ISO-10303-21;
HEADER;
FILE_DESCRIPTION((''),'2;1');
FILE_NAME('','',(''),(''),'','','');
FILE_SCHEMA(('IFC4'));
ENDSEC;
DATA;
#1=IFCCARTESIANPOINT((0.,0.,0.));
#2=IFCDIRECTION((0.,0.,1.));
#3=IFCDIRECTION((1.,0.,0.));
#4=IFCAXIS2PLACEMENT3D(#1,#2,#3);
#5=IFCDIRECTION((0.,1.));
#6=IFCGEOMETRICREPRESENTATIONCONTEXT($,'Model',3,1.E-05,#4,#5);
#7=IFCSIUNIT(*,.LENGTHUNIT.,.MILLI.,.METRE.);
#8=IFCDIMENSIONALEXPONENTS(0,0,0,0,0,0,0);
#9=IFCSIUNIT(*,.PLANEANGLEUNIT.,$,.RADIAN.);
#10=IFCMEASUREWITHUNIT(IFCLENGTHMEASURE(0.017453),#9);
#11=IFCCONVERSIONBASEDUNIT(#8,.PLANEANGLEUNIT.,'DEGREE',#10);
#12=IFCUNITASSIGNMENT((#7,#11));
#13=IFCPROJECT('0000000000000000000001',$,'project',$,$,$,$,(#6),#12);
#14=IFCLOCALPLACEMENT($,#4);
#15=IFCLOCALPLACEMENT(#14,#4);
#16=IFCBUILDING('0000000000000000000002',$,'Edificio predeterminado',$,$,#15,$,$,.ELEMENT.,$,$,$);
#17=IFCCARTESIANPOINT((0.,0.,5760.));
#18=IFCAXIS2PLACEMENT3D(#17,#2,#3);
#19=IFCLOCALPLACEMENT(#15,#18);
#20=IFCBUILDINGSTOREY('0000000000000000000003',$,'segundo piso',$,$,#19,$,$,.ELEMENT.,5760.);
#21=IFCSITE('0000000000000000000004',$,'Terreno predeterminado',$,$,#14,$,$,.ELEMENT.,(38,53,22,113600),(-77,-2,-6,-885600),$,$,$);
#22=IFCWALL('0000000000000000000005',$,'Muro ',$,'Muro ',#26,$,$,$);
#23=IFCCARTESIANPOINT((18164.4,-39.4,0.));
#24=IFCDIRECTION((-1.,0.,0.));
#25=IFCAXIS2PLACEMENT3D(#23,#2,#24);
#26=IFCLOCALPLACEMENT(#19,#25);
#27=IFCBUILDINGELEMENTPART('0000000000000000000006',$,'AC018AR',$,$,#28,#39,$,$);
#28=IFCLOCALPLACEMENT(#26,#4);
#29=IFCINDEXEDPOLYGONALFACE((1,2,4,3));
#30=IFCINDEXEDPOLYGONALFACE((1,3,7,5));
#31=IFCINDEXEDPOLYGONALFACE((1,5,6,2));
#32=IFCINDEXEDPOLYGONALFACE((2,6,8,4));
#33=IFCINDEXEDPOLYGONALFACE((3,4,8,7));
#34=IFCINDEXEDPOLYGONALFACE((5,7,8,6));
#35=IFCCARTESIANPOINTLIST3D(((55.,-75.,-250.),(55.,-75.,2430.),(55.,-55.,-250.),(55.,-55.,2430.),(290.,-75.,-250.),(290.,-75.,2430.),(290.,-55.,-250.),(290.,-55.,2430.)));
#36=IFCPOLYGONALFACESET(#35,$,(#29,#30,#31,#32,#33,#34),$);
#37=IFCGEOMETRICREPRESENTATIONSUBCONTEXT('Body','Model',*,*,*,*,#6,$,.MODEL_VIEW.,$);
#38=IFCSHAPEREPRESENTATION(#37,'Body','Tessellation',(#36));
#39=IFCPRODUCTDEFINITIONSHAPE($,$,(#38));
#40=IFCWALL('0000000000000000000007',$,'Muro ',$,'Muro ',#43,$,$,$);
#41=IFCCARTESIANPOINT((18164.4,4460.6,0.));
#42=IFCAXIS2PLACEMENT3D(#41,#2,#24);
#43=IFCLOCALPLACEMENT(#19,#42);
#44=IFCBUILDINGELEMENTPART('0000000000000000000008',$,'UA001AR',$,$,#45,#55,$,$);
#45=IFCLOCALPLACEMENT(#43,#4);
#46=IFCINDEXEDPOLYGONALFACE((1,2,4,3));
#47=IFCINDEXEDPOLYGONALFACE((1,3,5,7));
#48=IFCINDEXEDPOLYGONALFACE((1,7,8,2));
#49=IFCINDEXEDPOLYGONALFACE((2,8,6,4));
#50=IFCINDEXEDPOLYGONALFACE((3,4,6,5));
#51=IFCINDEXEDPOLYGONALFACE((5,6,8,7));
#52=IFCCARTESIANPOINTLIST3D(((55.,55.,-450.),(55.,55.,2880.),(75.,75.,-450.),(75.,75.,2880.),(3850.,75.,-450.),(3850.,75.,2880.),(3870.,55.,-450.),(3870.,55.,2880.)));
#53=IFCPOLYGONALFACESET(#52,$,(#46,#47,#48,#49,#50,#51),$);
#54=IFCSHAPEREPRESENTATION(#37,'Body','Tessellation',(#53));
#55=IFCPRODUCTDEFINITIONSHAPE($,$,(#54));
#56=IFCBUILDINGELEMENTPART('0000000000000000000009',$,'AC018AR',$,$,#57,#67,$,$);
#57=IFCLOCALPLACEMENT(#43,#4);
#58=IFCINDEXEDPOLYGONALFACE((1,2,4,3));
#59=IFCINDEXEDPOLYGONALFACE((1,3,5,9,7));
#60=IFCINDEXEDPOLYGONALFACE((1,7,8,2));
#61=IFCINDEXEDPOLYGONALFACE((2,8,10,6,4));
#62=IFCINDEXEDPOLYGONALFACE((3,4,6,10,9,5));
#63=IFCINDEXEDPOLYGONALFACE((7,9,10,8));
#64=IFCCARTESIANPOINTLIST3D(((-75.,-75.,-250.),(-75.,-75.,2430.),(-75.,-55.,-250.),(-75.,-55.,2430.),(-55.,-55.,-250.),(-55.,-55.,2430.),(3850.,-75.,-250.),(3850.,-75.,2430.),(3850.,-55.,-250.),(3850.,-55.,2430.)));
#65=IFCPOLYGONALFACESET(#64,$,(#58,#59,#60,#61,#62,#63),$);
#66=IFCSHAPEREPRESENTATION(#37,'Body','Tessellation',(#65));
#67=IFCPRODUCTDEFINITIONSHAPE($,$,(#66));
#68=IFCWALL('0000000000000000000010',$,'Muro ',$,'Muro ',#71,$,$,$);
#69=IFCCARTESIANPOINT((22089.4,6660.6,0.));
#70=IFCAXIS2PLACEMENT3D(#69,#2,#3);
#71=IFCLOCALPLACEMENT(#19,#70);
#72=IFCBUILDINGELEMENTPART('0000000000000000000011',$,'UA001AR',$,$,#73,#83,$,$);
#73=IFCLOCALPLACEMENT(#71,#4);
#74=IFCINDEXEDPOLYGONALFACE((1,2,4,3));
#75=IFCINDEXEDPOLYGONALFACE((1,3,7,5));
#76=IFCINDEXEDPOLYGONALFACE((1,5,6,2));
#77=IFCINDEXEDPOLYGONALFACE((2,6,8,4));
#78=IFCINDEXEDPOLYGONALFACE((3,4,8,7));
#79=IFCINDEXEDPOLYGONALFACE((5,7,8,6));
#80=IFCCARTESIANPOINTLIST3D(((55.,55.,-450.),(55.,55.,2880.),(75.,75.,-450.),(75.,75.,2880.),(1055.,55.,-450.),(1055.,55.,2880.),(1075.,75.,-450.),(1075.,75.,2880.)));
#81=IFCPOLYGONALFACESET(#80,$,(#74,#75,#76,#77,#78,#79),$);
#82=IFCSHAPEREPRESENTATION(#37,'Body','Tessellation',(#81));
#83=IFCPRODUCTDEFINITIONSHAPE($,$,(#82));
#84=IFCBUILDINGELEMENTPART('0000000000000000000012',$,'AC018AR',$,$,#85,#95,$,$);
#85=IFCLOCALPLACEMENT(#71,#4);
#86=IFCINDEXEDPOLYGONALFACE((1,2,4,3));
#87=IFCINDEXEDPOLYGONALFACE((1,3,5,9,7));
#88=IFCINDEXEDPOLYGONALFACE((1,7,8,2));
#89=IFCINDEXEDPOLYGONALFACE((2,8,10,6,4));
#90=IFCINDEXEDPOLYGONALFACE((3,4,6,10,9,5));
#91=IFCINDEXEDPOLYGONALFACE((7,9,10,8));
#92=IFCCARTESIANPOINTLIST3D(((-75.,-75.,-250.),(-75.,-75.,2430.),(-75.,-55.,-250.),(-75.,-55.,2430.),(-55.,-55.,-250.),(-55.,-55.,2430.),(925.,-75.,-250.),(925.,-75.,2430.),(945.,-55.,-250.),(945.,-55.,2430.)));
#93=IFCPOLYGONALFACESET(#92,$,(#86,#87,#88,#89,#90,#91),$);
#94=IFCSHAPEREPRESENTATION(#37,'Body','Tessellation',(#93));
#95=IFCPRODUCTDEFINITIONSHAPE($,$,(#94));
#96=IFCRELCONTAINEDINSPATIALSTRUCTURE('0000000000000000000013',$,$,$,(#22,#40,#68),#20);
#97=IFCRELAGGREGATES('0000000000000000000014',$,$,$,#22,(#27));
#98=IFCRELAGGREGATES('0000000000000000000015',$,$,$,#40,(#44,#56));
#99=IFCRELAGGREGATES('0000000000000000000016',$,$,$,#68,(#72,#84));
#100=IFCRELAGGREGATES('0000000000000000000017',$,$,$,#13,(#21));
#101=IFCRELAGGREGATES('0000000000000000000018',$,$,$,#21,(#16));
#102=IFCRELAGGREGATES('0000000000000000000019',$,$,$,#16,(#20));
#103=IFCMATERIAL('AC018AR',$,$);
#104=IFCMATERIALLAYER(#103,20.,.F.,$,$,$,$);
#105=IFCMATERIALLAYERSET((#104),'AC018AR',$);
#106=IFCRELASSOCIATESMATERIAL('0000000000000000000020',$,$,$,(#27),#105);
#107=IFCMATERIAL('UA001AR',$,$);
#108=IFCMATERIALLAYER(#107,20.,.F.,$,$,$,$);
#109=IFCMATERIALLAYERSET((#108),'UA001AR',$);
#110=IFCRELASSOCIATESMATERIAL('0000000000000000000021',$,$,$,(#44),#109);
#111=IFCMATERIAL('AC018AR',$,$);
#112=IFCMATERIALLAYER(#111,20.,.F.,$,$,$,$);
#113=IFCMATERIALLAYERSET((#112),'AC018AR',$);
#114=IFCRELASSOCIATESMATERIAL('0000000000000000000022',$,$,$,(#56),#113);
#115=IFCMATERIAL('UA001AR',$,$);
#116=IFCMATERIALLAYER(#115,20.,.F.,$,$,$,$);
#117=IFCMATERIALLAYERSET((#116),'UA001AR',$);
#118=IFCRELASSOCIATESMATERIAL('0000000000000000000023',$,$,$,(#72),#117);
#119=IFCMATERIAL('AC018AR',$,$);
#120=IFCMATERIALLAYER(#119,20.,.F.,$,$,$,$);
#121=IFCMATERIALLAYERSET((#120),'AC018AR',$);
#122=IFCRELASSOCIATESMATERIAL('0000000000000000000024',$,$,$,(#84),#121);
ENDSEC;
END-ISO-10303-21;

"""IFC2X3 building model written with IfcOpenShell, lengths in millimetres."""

from ifc_helpers import new_model, entity, si_unit, converted_unit, direction, frame, origin_with_axes, place, context, subcontext, project, spatial, polyline, outline, extrude, material, layer, layer_set, layer_usage, element, aggregate, save


model = new_model("IFC2X3")

# Units and contexts
model_context = context("Model", 3, precision=1e-05, world=origin_with_axes(), true_north=direction((0.0, 1.0)))
body_context = subcontext(model_context, "Body", "Model", "MODEL_VIEW")
ifc_project = project(units=[si_unit("LENGTHUNIT", "METRE", prefix="MILLI"), converted_unit("PLANEANGLEUNIT", "DEGREE", entity("IfcLengthMeasure", 0.017453), si_unit("PLANEANGLEUNIT", "RADIAN"), dimensions=[0, 0, 0, 0, 0, 0, 0])], contexts=[model_context])

# Site, building, storey
site_placement = place(None, origin_with_axes())
site = spatial("IfcSite", under=ifc_project, at=site_placement, Name="Terreno predeterminado", CompositionType="ELEMENT", RefLatitude=(38, 53, 22, 113600), RefLongitude=(-77, -2, -6, -885600))
building_placement = place(site_placement, origin_with_axes())
building = spatial("IfcBuilding", under=site, at=building_placement, Name="Edificio predeterminado", CompositionType="ELEMENT")
storey_placement = place(building_placement, frame((0.0, 0.0, 5760.0), z_axis=(0.0, 0.0, 1.0), x_axis=(1.0, 0.0, 0.0)))
storey = spatial("IfcBuildingStorey", under=building, at=storey_placement, Name="segundo piso", CompositionType="ELEMENT", Elevation=5760.0)

# Wall, building element part
wall_1_placement = place(storey_placement, frame((18164.4, -39.4, 0.0), z_axis=(0.0, 0.0, 1.0), x_axis=(-1.0, 0.0, 0.0)))
wall_1 = element("IfcWall", 1, at=wall_1_placement, inside=storey, Name="Muro ", ObjectType="Muro ")
ifc_material_1 = material(Name="AC018AR")
ifc_layer_1 = layer(ifc_material_1, 20.0, ventilated=False)
ifc_layer_set_1 = layer_set([ifc_layer_1], Name="AC018AR")
ifc_layer_usage_1 = layer_usage(ifc_layer_set_1, "AXIS2", "NEGATIVE", 55.0)
building_element_part_1_placement = place(wall_1_placement, origin_with_axes())
building_element_part_1 = element("IfcBuildingElementPart", 2, at=building_element_part_1_placement, material=ifc_layer_usage_1, Name="AC018AR", context=body_context, shape_type="SweptSolid", body=[
    extrude(outline(polyline([(290.0, -55.0), (290.0, -75.0), (55.0, -75.0), (55.0, -55.0), (290.0, -55.0)])), frame((0.0, 0.0, -250.0), z_axis=(0.0, 0.0, 1.0), x_axis=(1.0, 0.0, 0.0)), (0.0, 0.0, 1.0), 2680.0),
])
aggregate(wall_1, [building_element_part_1])

# Walls, building element parts
wall_2_placement = place(storey_placement, frame((18164.4, 4460.6, 0.0), z_axis=(0.0, 0.0, 1.0), x_axis=(-1.0, 0.0, 0.0)))
wall_2 = element("IfcWall", 3, at=wall_2_placement, inside=storey, Name="Muro ", ObjectType="Muro ")
ifc_material_2 = material(Name="UA001AR")
ifc_layer_2 = layer(ifc_material_2, 20.0, ventilated=False)
ifc_layer_set_2 = layer_set([ifc_layer_2], Name="UA001AR")
ifc_layer_usage_2 = layer_usage(ifc_layer_set_2, "AXIS2", "NEGATIVE", -75.0)
building_element_part_2_placement = place(wall_2_placement, origin_with_axes())
building_element_part_2 = element("IfcBuildingElementPart", 4, at=building_element_part_2_placement, material=ifc_layer_usage_2, Name="UA001AR", context=body_context, shape_type="SweptSolid", body=[
    extrude(outline(polyline([(3850.0, 75.0), (3870.0, 55.0), (55.0, 55.0), (75.0, 75.0), (3850.0, 75.0)])), frame((0.0, 0.0, -450.0), z_axis=(0.0, 0.0, 1.0), x_axis=(1.0, 0.0, 0.0)), (0.0, 0.0, 1.0), 3330.0),
])
ifc_material_3 = material(Name="AC018AR")
ifc_layer_3 = layer(ifc_material_3, 20.0, ventilated=False)
ifc_layer_set_3 = layer_set([ifc_layer_3], Name="AC018AR")
ifc_layer_usage_3 = layer_usage(ifc_layer_set_3, "AXIS2", "NEGATIVE", 55.0)
building_element_part_3_placement = place(wall_2_placement, origin_with_axes())
building_element_part_3 = element("IfcBuildingElementPart", 5, at=building_element_part_3_placement, material=ifc_layer_usage_3, Name="AC018AR", context=body_context, shape_type="SweptSolid", body=[
    extrude(outline(polyline([(3850.0, -55.0), (3850.0, -75.0), (-75.0, -75.0), (-75.0, -55.0), (-55.0, -55.0), (3850.0, -55.0)])), frame((0.0, 0.0, -250.0), z_axis=(0.0, 0.0, 1.0), x_axis=(1.0, 0.0, 0.0)), (0.0, 0.0, 1.0), 2680.0),
])
aggregate(wall_2, [building_element_part_2, building_element_part_3])
wall_3_placement = place(storey_placement, frame((22089.4, 6660.6, 0.0), z_axis=(0.0, 0.0, 1.0), x_axis=(1.0, 0.0, 0.0)))
wall_3 = element("IfcWall", 6, at=wall_3_placement, inside=storey, Name="Muro ", ObjectType="Muro ")
ifc_material_4 = material(Name="UA001AR")
ifc_layer_4 = layer(ifc_material_4, 20.0, ventilated=False)
ifc_layer_set_4 = layer_set([ifc_layer_4], Name="UA001AR")
ifc_layer_usage_4 = layer_usage(ifc_layer_set_4, "AXIS2", "NEGATIVE", -75.0)
building_element_part_4_placement = place(wall_3_placement, origin_with_axes())
building_element_part_4 = element("IfcBuildingElementPart", 7, at=building_element_part_4_placement, material=ifc_layer_usage_4, Name="UA001AR", context=body_context, shape_type="SweptSolid", body=[
    extrude(outline(polyline([(1075.0, 75.0), (1055.0, 55.0), (55.0, 55.0), (75.0, 75.0), (1075.0, 75.0)])), frame((0.0, 0.0, -450.0), z_axis=(0.0, 0.0, 1.0), x_axis=(1.0, 0.0, 0.0)), (0.0, 0.0, 1.0), 3330.0),
])
ifc_material_5 = material(Name="AC018AR")
ifc_layer_5 = layer(ifc_material_5, 20.0, ventilated=False)
ifc_layer_set_5 = layer_set([ifc_layer_5], Name="AC018AR")
ifc_layer_usage_5 = layer_usage(ifc_layer_set_5, "AXIS2", "NEGATIVE", 55.0)
building_element_part_5_placement = place(wall_3_placement, origin_with_axes())
building_element_part_5 = element("IfcBuildingElementPart", 8, at=building_element_part_5_placement, material=ifc_layer_usage_5, Name="AC018AR", context=body_context, shape_type="SweptSolid", body=[
    extrude(outline(polyline([(945.0, -55.0), (925.0, -75.0), (-75.0, -75.0), (-75.0, -55.0), (-55.0, -55.0), (945.0, -55.0)])), frame((0.0, 0.0, -250.0), z_axis=(0.0, 0.0, 1.0), x_axis=(1.0, 0.0, 0.0)), (0.0, 0.0, 1.0), 2680.0),
])
aggregate(wall_3, [building_element_part_4, building_element_part_5])

save(model, "model.ifc")
